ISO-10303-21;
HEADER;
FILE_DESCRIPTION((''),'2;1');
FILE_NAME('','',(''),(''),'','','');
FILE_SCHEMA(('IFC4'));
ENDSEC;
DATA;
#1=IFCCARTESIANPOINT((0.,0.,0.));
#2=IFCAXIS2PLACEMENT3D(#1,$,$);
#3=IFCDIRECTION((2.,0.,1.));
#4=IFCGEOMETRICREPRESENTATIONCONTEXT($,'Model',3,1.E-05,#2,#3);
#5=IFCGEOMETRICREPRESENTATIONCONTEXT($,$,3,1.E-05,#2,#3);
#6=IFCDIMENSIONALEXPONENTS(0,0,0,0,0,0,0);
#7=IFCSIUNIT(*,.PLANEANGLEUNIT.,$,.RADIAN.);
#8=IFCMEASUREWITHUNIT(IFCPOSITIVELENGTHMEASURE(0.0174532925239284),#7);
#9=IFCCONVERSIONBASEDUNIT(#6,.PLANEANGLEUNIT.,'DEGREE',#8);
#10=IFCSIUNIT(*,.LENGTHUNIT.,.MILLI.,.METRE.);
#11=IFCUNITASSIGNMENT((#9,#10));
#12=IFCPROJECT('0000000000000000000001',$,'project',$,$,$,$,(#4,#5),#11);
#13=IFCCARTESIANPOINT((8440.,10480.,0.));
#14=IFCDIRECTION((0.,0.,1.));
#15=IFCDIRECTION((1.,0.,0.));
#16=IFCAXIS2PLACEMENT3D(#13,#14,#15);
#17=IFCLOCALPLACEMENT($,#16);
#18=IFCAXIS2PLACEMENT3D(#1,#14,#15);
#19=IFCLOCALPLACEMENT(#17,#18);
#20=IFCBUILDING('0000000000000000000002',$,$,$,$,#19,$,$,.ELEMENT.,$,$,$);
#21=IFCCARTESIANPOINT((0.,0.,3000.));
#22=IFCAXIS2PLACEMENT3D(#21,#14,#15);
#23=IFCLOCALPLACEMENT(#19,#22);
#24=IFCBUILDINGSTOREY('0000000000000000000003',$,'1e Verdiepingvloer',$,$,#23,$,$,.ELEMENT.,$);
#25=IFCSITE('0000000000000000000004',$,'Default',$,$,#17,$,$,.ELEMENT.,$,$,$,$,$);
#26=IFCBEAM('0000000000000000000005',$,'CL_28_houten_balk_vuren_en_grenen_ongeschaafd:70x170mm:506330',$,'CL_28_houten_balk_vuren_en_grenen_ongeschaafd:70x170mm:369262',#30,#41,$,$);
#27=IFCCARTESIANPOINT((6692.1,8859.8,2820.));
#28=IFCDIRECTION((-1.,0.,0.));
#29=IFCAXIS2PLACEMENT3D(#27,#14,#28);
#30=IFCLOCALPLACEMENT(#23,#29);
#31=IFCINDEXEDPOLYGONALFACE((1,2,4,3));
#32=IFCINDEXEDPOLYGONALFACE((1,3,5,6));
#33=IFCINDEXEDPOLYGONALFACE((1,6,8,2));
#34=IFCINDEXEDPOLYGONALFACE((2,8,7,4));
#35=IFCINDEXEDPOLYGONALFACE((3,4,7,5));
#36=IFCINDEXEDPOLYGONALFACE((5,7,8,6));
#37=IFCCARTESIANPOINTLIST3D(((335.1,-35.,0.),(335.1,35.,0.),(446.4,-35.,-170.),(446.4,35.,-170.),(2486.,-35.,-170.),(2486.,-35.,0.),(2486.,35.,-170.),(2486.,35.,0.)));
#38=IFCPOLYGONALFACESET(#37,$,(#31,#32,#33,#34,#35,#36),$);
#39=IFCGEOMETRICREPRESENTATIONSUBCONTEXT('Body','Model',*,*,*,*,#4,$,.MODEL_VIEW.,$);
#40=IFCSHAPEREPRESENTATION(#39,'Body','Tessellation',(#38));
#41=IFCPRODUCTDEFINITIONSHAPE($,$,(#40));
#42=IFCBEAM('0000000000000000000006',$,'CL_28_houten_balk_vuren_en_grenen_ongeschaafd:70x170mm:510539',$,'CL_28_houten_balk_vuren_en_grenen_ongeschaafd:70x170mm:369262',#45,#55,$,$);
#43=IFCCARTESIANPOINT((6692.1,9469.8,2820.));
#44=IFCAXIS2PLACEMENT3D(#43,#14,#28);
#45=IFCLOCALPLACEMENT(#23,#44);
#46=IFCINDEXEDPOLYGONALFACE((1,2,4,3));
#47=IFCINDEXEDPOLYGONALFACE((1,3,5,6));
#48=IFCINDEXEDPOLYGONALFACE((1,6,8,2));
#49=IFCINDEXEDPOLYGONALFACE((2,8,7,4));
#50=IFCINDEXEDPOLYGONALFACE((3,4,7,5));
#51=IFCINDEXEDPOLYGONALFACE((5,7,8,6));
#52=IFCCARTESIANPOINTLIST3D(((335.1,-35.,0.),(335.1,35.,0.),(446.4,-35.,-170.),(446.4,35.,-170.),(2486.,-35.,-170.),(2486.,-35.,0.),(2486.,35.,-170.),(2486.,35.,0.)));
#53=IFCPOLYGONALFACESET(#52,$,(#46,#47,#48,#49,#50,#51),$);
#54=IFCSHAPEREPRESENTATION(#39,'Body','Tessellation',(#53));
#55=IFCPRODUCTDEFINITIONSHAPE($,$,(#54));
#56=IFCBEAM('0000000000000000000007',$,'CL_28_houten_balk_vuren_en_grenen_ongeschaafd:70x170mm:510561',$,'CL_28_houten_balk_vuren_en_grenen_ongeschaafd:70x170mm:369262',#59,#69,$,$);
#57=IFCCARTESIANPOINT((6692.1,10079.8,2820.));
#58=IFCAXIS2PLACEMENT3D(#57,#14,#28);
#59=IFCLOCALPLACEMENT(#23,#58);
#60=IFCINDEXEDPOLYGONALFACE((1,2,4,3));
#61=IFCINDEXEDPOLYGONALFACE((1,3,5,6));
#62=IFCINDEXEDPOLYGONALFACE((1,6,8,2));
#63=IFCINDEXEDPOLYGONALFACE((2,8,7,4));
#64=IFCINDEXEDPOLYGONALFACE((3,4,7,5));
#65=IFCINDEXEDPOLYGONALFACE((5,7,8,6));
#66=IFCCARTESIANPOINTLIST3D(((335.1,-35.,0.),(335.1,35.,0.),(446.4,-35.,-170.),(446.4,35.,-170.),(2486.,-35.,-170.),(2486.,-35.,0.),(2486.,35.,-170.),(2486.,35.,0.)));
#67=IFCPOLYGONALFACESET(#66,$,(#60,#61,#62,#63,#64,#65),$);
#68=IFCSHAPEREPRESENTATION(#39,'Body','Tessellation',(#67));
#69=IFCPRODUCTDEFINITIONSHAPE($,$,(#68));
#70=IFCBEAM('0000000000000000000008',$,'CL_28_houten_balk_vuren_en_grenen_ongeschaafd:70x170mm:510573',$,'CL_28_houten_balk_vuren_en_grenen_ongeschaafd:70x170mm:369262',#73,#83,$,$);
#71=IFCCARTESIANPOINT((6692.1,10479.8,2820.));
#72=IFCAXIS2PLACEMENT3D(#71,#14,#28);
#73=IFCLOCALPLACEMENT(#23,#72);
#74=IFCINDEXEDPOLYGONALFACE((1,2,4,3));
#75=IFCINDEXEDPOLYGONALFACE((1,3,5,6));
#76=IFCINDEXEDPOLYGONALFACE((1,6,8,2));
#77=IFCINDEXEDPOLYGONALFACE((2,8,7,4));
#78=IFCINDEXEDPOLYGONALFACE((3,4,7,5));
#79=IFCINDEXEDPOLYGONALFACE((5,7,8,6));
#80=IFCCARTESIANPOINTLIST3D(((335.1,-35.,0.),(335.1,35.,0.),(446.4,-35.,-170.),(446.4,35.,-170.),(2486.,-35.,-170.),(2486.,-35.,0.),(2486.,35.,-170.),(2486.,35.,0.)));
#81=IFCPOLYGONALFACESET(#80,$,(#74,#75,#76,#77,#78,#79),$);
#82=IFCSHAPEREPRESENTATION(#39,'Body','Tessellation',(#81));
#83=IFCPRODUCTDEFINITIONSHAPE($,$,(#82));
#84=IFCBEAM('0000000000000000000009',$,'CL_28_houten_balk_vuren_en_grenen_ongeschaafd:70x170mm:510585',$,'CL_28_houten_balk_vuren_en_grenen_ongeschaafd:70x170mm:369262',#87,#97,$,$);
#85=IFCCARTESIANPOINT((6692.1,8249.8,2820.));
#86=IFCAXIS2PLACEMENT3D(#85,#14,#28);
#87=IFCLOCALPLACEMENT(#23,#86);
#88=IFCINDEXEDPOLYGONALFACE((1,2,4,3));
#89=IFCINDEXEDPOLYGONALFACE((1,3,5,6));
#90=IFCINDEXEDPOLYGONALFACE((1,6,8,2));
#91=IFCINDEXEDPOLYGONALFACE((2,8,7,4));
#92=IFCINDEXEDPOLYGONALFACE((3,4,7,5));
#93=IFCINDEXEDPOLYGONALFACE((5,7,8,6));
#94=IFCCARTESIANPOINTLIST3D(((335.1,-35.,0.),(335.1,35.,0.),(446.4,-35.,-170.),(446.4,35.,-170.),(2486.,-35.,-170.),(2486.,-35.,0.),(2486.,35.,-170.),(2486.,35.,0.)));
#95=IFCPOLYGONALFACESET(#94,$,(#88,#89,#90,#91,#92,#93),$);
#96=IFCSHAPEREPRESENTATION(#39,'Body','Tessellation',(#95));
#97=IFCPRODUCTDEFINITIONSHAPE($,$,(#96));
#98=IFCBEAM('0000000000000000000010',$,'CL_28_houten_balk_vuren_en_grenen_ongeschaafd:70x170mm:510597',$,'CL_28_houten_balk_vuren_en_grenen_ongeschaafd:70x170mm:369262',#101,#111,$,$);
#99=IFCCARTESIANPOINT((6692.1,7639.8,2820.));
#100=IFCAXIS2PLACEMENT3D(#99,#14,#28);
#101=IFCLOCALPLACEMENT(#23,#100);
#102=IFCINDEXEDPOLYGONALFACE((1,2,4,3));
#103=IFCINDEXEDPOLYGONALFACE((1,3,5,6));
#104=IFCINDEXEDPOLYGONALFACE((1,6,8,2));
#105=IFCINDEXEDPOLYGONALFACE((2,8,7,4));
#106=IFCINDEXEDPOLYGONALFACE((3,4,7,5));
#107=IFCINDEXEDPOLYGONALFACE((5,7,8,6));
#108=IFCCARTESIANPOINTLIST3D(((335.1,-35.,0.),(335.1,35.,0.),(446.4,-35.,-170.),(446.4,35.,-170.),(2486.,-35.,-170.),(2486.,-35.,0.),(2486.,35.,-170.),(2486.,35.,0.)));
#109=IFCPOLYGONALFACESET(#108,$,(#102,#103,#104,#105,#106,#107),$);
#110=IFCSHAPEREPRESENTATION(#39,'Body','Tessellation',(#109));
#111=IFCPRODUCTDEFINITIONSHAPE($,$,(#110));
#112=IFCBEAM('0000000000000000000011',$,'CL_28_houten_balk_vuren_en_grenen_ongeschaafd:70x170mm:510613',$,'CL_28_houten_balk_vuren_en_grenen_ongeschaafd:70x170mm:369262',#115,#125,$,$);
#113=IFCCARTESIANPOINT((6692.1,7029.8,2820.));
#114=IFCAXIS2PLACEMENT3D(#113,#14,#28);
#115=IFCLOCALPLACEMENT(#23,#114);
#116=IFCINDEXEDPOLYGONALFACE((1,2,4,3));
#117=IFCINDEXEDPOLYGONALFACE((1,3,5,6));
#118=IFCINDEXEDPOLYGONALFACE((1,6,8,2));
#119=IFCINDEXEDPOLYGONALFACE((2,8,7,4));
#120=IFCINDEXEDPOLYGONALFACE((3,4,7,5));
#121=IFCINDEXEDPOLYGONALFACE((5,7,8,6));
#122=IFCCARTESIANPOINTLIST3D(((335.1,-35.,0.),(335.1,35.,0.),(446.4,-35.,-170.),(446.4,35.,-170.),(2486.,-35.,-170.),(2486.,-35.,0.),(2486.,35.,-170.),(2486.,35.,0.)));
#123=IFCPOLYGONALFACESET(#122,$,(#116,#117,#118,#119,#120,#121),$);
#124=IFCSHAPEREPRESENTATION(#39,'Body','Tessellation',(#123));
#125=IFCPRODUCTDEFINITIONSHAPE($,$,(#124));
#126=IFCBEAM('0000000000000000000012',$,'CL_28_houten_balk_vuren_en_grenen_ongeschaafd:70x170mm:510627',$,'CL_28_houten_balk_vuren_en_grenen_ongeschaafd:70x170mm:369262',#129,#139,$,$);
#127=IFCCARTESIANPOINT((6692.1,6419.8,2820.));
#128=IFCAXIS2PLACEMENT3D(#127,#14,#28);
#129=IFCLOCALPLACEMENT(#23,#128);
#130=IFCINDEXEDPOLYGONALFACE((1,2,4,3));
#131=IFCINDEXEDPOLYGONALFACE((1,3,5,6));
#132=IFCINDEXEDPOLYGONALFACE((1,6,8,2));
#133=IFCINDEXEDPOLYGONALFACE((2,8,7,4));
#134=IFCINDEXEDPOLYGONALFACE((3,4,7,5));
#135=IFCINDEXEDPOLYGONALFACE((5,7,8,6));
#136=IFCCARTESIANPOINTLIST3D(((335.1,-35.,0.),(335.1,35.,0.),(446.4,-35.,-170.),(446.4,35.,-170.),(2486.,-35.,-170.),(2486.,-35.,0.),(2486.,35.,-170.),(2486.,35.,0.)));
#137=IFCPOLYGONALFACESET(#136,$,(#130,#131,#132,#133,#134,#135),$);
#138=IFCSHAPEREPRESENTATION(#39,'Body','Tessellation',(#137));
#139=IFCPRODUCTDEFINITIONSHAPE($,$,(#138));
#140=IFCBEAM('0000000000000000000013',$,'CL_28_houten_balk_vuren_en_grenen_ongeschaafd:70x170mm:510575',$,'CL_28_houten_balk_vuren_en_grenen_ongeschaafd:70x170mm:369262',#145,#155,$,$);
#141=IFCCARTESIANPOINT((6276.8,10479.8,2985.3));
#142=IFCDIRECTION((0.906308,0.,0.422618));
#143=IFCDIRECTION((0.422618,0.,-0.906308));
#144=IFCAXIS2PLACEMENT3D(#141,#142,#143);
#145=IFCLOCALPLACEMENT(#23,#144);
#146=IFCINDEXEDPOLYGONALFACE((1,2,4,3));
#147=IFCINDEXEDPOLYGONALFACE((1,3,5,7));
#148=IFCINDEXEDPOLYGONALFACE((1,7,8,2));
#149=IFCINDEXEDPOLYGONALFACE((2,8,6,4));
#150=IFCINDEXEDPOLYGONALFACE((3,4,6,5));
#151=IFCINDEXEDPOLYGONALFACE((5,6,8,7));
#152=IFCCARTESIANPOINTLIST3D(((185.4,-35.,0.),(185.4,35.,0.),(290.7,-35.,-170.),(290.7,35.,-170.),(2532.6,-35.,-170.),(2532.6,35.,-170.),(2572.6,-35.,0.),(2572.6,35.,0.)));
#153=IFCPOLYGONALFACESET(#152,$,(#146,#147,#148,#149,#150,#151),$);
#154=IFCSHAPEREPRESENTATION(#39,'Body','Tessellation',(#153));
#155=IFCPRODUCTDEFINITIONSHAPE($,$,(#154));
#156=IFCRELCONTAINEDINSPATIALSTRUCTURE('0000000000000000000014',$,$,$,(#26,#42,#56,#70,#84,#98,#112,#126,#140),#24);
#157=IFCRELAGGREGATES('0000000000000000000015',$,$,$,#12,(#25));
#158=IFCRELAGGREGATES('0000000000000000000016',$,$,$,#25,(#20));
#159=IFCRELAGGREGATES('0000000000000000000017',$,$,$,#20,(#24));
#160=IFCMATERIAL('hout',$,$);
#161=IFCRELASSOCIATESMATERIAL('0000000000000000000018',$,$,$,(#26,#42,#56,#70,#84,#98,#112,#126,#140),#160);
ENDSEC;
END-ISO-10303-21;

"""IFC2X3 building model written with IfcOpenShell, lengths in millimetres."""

from ifc_helpers import new_model, entity, si_unit, converted_unit, direction, frame, frame_2d, origin, origin_with_axes, place, context, subcontext, project, spatial, rectangle, extrude, clip, halfspace, source, transform, mapped, material, element, save


model = new_model("IFC2X3")

# Units and contexts
model_context = context("Model", 3, precision=1e-05, world=origin(), true_north=direction((2.0, 0.0, 1.0)))
context_of_model = context(None, 3, precision=1e-05, world=origin(), true_north=direction((2.0, 0.0, 1.0)))
body_context = subcontext(model_context, "Body", "Model", "MODEL_VIEW")
ifc_project = project(units=[converted_unit("PLANEANGLEUNIT", "DEGREE", entity("IfcPositiveLengthMeasure", 0.0174532925239284), si_unit("PLANEANGLEUNIT", "RADIAN"), dimensions=[0, 0, 0, 0, 0, 0, 0]), si_unit("LENGTHUNIT", "METRE", prefix="MILLI")], contexts=[model_context, context_of_model])

# Site, building, storey
site_placement = place(None, frame((8440.0, 10480.0, 0.0), z_axis=(0.0, 0.0, 1.0), x_axis=(1.0, 0.0, 0.0)))
site = spatial("IfcSite", under=ifc_project, at=site_placement, Name="Default", CompositionType="ELEMENT")
building_placement = place(site_placement, origin_with_axes())
building = spatial("IfcBuilding", under=site, at=building_placement, CompositionType="ELEMENT")
storey_placement = place(building_placement, frame((0.0, 0.0, 3000.0), z_axis=(0.0, 0.0, 1.0), x_axis=(1.0, 0.0, 0.0)))
storey = spatial("IfcBuildingStorey", under=building, at=storey_placement, Name="1e Verdiepingvloer", CompositionType="ELEMENT")

# Beams
ifc_material_1 = material(Name="hout")
shared_shape_1 = source(origin(), body_context, "Body", "Clipping", [
    clip(extrude(rectangle(XDim=170.0, YDim=70.0, at=frame_2d((0.0, 0.0), x_axis=(1.0, 0.0))), frame((335.1, 0.0, -85.0), z_axis=(1.0, 0.0, 0.0), x_axis=(0.0, 0.0, -1.0)), (0.0, 0.0, 1.0), 2150.9), halfspace(frame((446.4, 1070.7, -170.0), z_axis=(-0.836561, 0.0, -0.547874), x_axis=(-0.547874, 0.0, 0.836561)), False)),
])
for number, where, z_axis, x_axis, name in (
    (1, (6692.1, 8859.8, 2820.0), (0.0, 0.0, 1.0), (-1.0, 0.0, 0.0), "CL_28_houten_balk_vuren_en_grenen_ongeschaafd:70x170mm:506330"),
    (2, (6692.1, 9469.8, 2820.0), (0.0, 0.0, 1.0), (-1.0, 0.0, 0.0), "CL_28_houten_balk_vuren_en_grenen_ongeschaafd:70x170mm:510539"),
    (3, (6692.1, 10079.8, 2820.0), (0.0, 0.0, 1.0), (-1.0, 0.0, 0.0), "CL_28_houten_balk_vuren_en_grenen_ongeschaafd:70x170mm:510561"),
    (4, (6692.1, 10479.8, 2820.0), (0.0, 0.0, 1.0), (-1.0, 0.0, 0.0), "CL_28_houten_balk_vuren_en_grenen_ongeschaafd:70x170mm:510573"),
    (5, (6692.1, 8249.8, 2820.0), (0.0, 0.0, 1.0), (-1.0, 0.0, 0.0), "CL_28_houten_balk_vuren_en_grenen_ongeschaafd:70x170mm:510585"),
    (6, (6692.1, 7639.8, 2820.0), (0.0, 0.0, 1.0), (-1.0, 0.0, 0.0), "CL_28_houten_balk_vuren_en_grenen_ongeschaafd:70x170mm:510597"),
    (7, (6692.1, 7029.8, 2820.0), (0.0, 0.0, 1.0), (-1.0, 0.0, 0.0), "CL_28_houten_balk_vuren_en_grenen_ongeschaafd:70x170mm:510613"),
    (8, (6692.1, 6419.8, 2820.0), (0.0, 0.0, 1.0), (-1.0, 0.0, 0.0), "CL_28_houten_balk_vuren_en_grenen_ongeschaafd:70x170mm:510627"),
):
    element("IfcBeam", number, at=place(storey_placement, frame(where, z_axis=z_axis, x_axis=x_axis)), inside=storey, material=ifc_material_1, Name=name, ObjectType="CL_28_houten_balk_vuren_en_grenen_ongeschaafd:70x170mm:369262", context=body_context, shape_type="MappedRepresentation", body=[
        mapped(shared_shape_1, transform((0.0, 0.0, 0.0))),
    ])
shared_shape_2 = source(origin(), body_context, "Body", "Clipping", [
    clip(clip(extrude(rectangle(XDim=170.0, YDim=70.0, at=frame_2d((0.0, 0.0), x_axis=(1.0, 0.0))), frame((185.4, 0.0, -85.0), z_axis=(1.0, 0.0, 0.0), x_axis=(0.0, 0.0, -1.0)), (0.0, 0.0, 1.0), 2387.2), halfspace(frame((2532.6, -2690.7, -170.0), z_axis=(0.973348, 0.0, -0.229334), x_axis=(0.229334, 0.0, 0.973348)), False)), halfspace(frame((290.7, -2690.7, -170.0), z_axis=(-0.850088, 0.0, -0.52664), x_axis=(-0.52664, 0.0, 0.850088)), False)),
])
beam_1_placement = place(storey_placement, frame((6276.8, 10479.8, 2985.3), z_axis=(0.906308, 0.0, 0.422618), x_axis=(0.422618, 0.0, -0.906308)))
element("IfcBeam", 9, at=beam_1_placement, inside=storey, material=ifc_material_1, Name="CL_28_houten_balk_vuren_en_grenen_ongeschaafd:70x170mm:510575", ObjectType="CL_28_houten_balk_vuren_en_grenen_ongeschaafd:70x170mm:369262", context=body_context, shape_type="MappedRepresentation", body=[
    mapped(shared_shape_2, transform((0.0, 0.0, 0.0))),
])

save(model, "model.ifc")
